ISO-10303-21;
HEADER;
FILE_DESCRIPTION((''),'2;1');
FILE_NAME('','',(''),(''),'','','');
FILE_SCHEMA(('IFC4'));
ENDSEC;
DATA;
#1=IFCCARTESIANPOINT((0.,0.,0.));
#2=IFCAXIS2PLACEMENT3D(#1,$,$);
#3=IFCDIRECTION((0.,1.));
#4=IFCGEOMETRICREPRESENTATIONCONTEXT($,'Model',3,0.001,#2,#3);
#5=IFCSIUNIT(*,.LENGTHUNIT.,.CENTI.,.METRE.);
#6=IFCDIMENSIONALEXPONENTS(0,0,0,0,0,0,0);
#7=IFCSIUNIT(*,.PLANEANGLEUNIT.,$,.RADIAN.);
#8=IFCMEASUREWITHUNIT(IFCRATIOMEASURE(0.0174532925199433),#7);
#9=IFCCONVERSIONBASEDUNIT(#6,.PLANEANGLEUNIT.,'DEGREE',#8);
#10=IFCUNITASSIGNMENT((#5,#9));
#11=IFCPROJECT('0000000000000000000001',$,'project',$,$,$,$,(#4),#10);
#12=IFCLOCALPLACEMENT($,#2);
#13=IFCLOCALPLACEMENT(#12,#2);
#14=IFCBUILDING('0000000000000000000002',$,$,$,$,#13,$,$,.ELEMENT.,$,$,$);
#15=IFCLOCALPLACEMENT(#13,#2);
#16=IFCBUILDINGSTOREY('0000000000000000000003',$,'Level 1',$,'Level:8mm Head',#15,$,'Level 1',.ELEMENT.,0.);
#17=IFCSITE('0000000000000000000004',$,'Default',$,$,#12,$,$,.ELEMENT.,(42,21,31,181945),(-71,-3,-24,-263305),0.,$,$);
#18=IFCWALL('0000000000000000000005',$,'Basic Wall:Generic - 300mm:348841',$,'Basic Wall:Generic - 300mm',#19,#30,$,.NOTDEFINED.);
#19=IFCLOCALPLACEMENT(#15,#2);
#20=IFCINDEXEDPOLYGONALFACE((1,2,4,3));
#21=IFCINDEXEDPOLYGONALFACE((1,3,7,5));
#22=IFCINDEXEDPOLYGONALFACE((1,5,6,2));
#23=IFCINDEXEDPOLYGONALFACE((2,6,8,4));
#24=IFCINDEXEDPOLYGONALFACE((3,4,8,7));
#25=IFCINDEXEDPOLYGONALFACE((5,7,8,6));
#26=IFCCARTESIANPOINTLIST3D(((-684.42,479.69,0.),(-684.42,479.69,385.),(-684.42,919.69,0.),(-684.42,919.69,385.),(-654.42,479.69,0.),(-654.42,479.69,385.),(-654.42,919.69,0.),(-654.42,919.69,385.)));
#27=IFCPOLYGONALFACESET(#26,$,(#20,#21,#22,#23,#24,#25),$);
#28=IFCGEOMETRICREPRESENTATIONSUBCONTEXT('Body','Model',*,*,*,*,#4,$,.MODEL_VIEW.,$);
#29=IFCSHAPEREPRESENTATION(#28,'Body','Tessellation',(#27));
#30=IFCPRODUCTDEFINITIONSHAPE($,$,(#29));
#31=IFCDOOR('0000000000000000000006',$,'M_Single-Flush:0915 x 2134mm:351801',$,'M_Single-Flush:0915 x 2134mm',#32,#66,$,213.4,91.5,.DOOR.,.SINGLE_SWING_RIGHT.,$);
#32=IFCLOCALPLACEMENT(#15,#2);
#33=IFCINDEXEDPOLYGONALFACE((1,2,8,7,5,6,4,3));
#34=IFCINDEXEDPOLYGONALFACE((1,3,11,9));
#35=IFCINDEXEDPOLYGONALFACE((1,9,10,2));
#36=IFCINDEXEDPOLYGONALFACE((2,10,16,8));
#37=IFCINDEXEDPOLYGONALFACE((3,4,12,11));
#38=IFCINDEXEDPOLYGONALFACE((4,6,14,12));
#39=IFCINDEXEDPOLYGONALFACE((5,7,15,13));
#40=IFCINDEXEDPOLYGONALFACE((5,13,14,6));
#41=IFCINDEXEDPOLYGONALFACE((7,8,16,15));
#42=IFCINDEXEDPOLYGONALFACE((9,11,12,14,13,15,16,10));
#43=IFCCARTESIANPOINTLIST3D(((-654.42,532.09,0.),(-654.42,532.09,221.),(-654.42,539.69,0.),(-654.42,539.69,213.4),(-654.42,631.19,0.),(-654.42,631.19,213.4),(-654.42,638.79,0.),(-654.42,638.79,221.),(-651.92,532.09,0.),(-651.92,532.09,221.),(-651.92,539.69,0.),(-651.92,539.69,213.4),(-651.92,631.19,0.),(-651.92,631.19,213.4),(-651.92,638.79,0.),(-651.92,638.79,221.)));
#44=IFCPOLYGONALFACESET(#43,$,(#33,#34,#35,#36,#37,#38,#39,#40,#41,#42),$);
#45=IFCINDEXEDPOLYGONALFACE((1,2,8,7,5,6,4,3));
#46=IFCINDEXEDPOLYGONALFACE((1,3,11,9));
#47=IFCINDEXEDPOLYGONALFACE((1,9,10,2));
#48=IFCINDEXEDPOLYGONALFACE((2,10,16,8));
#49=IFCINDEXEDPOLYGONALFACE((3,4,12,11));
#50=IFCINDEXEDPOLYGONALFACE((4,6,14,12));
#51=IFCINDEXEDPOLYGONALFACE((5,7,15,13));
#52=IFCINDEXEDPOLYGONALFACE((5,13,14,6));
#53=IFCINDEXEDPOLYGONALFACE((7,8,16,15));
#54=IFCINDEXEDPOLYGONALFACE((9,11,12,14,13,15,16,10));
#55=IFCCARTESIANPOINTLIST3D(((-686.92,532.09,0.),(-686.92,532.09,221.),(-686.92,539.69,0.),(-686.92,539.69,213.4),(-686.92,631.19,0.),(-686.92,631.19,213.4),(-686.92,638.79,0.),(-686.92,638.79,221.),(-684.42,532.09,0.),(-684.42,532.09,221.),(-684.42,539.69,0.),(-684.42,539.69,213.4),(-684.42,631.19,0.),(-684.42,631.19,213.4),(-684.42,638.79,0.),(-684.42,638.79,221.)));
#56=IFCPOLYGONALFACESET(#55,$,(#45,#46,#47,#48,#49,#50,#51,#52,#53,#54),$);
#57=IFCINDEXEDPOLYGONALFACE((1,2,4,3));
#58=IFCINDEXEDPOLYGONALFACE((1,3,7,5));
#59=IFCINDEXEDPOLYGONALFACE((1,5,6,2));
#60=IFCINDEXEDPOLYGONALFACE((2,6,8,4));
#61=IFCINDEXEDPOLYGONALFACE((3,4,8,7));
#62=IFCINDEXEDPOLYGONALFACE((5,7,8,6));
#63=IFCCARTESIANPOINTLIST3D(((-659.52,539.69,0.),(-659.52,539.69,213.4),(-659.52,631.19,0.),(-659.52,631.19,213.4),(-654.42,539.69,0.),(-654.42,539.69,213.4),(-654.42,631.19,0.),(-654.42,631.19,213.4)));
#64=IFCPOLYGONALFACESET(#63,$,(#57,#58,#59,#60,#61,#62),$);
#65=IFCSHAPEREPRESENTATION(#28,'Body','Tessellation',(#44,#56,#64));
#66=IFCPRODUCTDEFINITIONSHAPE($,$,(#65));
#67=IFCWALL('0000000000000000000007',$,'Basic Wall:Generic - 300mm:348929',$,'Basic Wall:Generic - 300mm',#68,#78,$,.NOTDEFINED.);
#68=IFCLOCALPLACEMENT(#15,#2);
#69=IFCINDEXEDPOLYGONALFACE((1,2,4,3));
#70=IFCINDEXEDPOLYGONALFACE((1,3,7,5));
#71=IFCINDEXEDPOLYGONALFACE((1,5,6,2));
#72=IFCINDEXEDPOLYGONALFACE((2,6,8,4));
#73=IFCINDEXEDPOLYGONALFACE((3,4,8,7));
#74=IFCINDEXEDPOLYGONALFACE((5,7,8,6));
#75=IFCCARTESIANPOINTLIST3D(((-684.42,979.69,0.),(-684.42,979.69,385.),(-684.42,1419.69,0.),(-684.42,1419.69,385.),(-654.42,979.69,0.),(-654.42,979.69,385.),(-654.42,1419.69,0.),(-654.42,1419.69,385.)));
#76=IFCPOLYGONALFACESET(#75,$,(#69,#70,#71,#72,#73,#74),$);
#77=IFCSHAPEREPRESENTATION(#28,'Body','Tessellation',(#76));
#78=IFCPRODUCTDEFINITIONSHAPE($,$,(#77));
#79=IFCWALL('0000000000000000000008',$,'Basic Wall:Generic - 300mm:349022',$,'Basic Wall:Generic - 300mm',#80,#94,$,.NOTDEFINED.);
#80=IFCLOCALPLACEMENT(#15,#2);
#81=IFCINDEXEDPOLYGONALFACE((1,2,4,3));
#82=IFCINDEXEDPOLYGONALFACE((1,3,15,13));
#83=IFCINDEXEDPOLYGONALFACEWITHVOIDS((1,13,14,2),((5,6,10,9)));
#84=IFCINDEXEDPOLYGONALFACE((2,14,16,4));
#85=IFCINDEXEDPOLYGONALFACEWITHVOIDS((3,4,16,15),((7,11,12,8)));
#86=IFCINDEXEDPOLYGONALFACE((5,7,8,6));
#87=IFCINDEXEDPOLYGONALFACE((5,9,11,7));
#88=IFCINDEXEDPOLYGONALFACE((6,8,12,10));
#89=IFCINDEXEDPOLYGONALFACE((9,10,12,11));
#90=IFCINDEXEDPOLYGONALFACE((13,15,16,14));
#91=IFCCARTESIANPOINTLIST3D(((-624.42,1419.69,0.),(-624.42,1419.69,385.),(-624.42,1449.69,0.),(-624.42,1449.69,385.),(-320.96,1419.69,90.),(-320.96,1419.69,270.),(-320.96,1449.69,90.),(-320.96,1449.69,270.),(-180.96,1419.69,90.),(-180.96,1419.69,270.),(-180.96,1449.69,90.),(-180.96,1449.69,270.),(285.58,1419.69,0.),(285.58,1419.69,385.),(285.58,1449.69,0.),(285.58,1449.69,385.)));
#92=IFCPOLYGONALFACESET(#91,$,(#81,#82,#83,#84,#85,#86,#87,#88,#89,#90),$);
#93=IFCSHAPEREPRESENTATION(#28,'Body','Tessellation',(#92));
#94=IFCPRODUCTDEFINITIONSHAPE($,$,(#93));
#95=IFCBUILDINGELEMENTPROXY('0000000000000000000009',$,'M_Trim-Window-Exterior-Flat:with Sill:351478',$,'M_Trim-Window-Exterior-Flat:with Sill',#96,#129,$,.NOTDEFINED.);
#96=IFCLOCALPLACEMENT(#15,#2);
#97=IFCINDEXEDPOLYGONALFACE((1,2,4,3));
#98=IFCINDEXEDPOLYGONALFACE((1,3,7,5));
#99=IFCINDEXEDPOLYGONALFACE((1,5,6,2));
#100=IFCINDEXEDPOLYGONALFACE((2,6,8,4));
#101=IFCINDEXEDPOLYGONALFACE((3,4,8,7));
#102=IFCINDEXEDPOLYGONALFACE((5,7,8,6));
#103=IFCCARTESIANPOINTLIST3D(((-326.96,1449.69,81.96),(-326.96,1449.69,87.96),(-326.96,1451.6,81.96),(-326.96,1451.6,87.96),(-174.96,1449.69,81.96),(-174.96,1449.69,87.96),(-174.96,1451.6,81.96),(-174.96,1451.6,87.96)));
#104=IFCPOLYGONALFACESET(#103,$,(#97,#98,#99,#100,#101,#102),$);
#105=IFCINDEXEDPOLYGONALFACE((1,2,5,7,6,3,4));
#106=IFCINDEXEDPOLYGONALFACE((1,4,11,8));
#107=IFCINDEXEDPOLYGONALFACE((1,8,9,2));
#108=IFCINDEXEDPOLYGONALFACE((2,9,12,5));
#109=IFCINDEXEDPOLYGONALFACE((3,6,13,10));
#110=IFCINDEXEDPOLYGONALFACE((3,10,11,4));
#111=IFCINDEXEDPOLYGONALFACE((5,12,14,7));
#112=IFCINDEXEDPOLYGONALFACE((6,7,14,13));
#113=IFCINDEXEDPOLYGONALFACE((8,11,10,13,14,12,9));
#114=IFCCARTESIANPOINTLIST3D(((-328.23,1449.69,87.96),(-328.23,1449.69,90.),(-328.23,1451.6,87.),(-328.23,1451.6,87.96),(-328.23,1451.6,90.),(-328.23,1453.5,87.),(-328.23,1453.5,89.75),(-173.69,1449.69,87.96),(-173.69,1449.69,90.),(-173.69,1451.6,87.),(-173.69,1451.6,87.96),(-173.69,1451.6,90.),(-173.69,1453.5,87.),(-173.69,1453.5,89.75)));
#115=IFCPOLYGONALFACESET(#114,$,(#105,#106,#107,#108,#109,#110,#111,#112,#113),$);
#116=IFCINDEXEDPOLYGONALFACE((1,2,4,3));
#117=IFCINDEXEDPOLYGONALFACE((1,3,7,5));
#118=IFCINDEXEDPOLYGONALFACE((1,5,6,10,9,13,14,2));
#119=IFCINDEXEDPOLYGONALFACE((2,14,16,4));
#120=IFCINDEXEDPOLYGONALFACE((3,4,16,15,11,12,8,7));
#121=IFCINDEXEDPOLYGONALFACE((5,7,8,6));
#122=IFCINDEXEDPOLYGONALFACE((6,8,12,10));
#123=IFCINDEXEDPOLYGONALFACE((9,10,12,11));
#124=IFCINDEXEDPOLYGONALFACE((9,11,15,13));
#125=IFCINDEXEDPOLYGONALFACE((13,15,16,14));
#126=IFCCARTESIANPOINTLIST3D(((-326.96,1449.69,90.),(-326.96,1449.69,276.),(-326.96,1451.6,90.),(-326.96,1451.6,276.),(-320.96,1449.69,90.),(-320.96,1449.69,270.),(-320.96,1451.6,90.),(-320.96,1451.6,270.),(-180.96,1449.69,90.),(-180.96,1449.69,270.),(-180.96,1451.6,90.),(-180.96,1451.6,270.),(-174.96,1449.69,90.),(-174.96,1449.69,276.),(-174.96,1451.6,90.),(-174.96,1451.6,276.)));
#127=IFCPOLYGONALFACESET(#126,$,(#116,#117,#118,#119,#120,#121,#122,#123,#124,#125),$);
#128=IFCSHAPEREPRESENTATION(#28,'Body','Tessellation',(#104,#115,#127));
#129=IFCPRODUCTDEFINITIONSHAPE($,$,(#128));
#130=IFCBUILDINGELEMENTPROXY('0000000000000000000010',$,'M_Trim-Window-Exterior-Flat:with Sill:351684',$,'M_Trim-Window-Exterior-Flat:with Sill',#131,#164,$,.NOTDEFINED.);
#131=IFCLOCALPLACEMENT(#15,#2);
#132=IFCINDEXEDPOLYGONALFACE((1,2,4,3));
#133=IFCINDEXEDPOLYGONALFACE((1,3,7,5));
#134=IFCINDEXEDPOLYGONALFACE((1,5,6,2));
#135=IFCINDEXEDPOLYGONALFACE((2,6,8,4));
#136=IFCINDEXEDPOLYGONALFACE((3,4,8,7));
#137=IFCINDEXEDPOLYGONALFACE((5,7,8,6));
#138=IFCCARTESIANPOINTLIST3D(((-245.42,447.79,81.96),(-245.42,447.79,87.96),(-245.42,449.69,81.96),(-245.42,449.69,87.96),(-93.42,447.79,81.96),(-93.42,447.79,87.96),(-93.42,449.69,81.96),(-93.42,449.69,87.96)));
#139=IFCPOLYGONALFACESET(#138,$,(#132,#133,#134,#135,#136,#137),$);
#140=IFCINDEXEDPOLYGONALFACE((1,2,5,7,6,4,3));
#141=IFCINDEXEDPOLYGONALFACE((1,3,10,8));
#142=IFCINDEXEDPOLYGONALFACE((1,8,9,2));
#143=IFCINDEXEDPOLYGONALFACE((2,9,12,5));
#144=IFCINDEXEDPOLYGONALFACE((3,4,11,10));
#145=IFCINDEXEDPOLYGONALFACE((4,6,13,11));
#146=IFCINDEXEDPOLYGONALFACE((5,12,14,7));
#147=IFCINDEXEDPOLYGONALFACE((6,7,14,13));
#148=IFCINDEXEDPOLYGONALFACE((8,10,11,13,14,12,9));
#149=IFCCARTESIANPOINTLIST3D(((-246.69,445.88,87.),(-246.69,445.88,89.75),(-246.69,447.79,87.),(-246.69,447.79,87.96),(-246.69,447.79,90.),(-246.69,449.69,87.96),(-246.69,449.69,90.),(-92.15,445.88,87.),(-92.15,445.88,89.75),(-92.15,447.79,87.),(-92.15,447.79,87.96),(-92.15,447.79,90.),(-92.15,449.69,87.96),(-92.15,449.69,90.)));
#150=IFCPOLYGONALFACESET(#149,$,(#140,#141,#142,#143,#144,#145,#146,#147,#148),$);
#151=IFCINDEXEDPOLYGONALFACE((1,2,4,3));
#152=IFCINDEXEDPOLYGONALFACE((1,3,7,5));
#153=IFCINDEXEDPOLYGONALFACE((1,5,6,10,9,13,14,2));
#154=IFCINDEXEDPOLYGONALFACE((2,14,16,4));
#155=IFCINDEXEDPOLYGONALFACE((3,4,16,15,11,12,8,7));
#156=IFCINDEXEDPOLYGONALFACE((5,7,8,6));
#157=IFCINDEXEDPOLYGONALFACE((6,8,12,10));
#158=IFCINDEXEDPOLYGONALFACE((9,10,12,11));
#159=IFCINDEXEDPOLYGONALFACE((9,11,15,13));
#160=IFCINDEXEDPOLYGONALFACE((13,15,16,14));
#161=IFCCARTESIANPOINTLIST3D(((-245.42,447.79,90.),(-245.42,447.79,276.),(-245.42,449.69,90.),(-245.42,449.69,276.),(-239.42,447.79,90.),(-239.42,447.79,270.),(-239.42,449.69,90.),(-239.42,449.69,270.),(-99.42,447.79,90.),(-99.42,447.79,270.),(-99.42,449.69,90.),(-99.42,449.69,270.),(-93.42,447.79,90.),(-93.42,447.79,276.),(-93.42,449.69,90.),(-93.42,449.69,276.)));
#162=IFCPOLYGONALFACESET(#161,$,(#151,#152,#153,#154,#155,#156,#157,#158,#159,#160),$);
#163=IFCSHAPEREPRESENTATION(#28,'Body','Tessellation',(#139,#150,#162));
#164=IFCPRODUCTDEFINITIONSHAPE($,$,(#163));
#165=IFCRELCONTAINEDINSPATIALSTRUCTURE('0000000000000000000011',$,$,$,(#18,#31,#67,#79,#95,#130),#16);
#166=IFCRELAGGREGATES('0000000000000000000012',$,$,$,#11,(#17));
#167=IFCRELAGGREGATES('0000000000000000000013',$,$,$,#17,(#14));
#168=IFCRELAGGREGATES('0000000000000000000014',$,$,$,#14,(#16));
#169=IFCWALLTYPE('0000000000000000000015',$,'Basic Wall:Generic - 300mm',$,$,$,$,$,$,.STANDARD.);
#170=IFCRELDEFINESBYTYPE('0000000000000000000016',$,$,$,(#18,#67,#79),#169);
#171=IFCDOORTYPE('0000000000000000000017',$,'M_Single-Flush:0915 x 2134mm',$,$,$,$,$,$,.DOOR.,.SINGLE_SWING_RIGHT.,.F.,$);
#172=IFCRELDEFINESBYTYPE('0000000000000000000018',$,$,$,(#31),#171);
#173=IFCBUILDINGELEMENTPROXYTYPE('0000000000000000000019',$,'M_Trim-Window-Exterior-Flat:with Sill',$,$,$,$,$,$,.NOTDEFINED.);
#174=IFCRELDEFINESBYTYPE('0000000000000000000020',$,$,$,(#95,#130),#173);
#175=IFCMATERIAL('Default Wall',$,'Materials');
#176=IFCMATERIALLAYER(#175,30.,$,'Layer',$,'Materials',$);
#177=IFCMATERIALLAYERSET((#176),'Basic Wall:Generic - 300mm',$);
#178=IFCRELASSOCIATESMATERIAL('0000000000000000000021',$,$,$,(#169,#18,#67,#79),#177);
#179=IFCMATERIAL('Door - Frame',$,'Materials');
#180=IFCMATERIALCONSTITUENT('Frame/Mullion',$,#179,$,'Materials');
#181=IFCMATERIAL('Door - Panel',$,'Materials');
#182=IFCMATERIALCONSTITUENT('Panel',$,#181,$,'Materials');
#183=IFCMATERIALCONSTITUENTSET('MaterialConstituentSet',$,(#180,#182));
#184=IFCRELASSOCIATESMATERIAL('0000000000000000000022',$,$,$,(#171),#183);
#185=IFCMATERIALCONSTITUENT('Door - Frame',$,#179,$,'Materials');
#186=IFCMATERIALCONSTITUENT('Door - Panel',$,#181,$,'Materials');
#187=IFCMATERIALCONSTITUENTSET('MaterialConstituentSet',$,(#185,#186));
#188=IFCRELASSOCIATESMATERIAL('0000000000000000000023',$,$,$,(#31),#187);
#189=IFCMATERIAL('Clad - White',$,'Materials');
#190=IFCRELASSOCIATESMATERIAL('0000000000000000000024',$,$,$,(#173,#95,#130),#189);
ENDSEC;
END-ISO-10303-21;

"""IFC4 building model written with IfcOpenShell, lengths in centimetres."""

from ifc_helpers import new_model, entity, si_unit, converted_unit, direction, frame, frame_2d, origin, place, context, subcontext, project, spatial, polyline, rectangle, outline, extrude, clip, bounded_halfspace, source, transform, mapped, material, layer, layer_set, layer_usage, constituent, constituent_set, type_object, type_shapes, element, fill, save


model = new_model("IFC4")

# Units and contexts
model_context = context("Model", 3, precision=0.001, world=origin(), true_north=direction((0.0, 1.0)))
body_context = subcontext(model_context, "Body", "Model", "MODEL_VIEW")
ifc_project = project(units=[si_unit("LENGTHUNIT", "METRE", prefix="CENTI"), converted_unit("PLANEANGLEUNIT", "DEGREE", entity("IfcRatioMeasure", 0.0174532925199433), si_unit("PLANEANGLEUNIT", "RADIAN"), dimensions=[0, 0, 0, 0, 0, 0, 0])], contexts=[model_context])

# Site, building, storey
site_placement = place(None, origin())
site = spatial("IfcSite", under=ifc_project, at=site_placement, Name="Default", CompositionType="ELEMENT", RefLatitude=(42, 21, 31, 181945), RefLongitude=(-71, -3, -24, -263305), RefElevation=0.0)
building_placement = place(site_placement, origin())
building = spatial("IfcBuilding", under=site, at=building_placement, CompositionType="ELEMENT")
storey_placement = place(building_placement, origin())
storey = spatial("IfcBuildingStorey", under=building, at=storey_placement, Name="Level 1", ObjectType="Level:8mm Head", LongName="Level 1", CompositionType="ELEMENT", Elevation=0.0)

# Shared definitions
ifc_material_1 = material(Name="Default Wall", Category="Materials")

# Wall, opening, door
ifc_layer_1 = layer(ifc_material_1, 30.0, Name="Layer", Category="Materials")
ifc_layer_set_1 = layer_set([ifc_layer_1], Name="Basic Wall:Generic - 300mm")
ifc_layer_usage_1 = layer_usage(ifc_layer_set_1, "AXIS2", "NEGATIVE", 15.0)
wall_type = type_object("IfcWallType", Name="Basic Wall:Generic - 300mm", PredefinedType="STANDARD", material=ifc_layer_set_1)
wall_1_placement = place(storey_placement, frame((-669.42, 479.69, 0.0), z_axis=(0.0, 0.0, 1.0), x_axis=(0.0, 1.0, 0.0)))
wall_1 = element("IfcWall", 1, at=wall_1_placement, inside=storey, type_object=wall_type, material=ifc_layer_usage_1, Name="Basic Wall:Generic - 300mm:348841", ObjectType="Basic Wall:Generic - 300mm", PredefinedType="NOTDEFINED", context=body_context, shape_type="Clipping", body=[
    clip(extrude(rectangle(XDim=440.0, YDim=30.0, at=frame_2d((220.0, 0.0), x_axis=(-1.0, 0.0))), origin(), (0.0, 0.0, 1.0), 385.0), bounded_halfspace(frame((0.0, -15.0, 385.0), z_axis=(0.0, 0.0, -1.0), x_axis=(0.0, -1.0, 0.0)), True, frame((0.0, -15.0, 385.0)), polyline([(0.0, 0.0), (440.0, 0.0), (440.0, 30.0), (0.0, 30.0), (0.0, 0.0)]))),
])
opening_1_placement = place(wall_1_placement, frame((151.5, 45.0, 0.0)))
opening_1 = element("IfcOpeningElement", 2, at=opening_1_placement, cuts=wall_1, PredefinedType="OPENING", context=body_context, shape_type="SweptSolid", body=[
    extrude(rectangle(XDim=91.5, YDim=213.4, at=frame_2d((106.7, 45.75), x_axis=(0.0, 1.0))), frame((0.0, 0.0, 0.0), z_axis=(0.0, -1.0, 0.0), x_axis=(0.0, 0.0, 1.0)), (0.0, 0.0, 1.0), 30.0),
])
ifc_material_2 = material(Name="Door - Frame", Category="Materials")
ifc_constituent_1 = constituent(ifc_material_2, Name="Door - Frame", Category="Materials")
ifc_material_3 = material(Name="Door - Panel", Category="Materials")
ifc_constituent_2 = constituent(ifc_material_3, Name="Door - Panel", Category="Materials")
ifc_constituent_set_1 = constituent_set(constituents=[ifc_constituent_1, ifc_constituent_2], Name="MaterialConstituentSet")
ifc_constituent_3 = constituent(ifc_material_2, Name="Frame/Mullion", Category="Materials")
ifc_constituent_4 = constituent(ifc_material_3, Name="Panel", Category="Materials")
ifc_constituent_set_2 = constituent_set(constituents=[ifc_constituent_3, ifc_constituent_4], Name="MaterialConstituentSet")
door_type = type_object("IfcDoorType", Name="M_Single-Flush:0915 x 2134mm", OperationType="SINGLE_SWING_RIGHT", ParameterTakesPrecedence=False, PredefinedType="DOOR", material=ifc_constituent_set_2)
shared_shape_1 = source(origin(), body_context, "Body", "SweptSolid", [
    extrude(outline(polyline([(-53.35, -112.4), (53.35, -112.4), (53.35, 108.6), (45.75, 108.6), (45.75, -104.8), (-45.75, -104.8), (-45.75, 108.6), (-53.35, 108.6), (-53.35, -112.4)])), frame((45.75, 30.0, 108.6), z_axis=(0.0, 1.0, 0.0), x_axis=(1.0, 0.0, 0.0)), (0.0, 0.0, 1.0), 2.5),
    extrude(outline(polyline([(-112.4, -53.35), (108.6, -53.35), (108.6, -45.75), (-104.8, -45.75), (-104.8, 45.75), (108.6, 45.75), (108.6, 53.35), (-112.4, 53.35), (-112.4, -53.35)])), frame((45.75, -2.5, 108.6), z_axis=(0.0, 1.0, 0.0), x_axis=(0.0, 0.0, -1.0)), (0.0, 0.0, 1.0), 2.5),
    extrude(rectangle(XDim=5.1, YDim=91.5, at=frame_2d((0.0, 0.0), x_axis=(1.0, 0.0))), frame((45.75, 27.45, 0.0), z_axis=(0.0, 0.0, 1.0), x_axis=(0.0, 1.0, 0.0)), (0.0, 0.0, 1.0), 213.4),
])
type_shapes(door_type, [shared_shape_1])
door_placement = place(opening_1_placement, frame((0.0, -30.0, 0.0), z_axis=(0.0, 0.0, 1.0), x_axis=(-1.0, 0.0, 0.0)))
door = element("IfcDoor", 3, at=door_placement, inside=storey, type_object=door_type, material=ifc_constituent_set_1, Name="M_Single-Flush:0915 x 2134mm:351801", ObjectType="M_Single-Flush:0915 x 2134mm", OperationType="SINGLE_SWING_RIGHT", OverallHeight=213.4, OverallWidth=91.5, PredefinedType="DOOR", context=body_context, shape_type="MappedRepresentation", body=[
    mapped(shared_shape_1, transform((0.0, 0.0, 0.0), scale=1.0)),
])
fill(opening_1, door)

# Wall
ifc_layer_usage_2 = layer_usage(ifc_layer_set_1, "AXIS2", "NEGATIVE", 15.0)
wall_2_placement = place(storey_placement, frame((-669.42, 979.69, 0.0), z_axis=(0.0, 0.0, 1.0), x_axis=(0.0, 1.0, 0.0)))
element("IfcWall", 4, at=wall_2_placement, inside=storey, type_object=wall_type, material=ifc_layer_usage_2, Name="Basic Wall:Generic - 300mm:348929", ObjectType="Basic Wall:Generic - 300mm", PredefinedType="NOTDEFINED", context=body_context, shape_type="Clipping", body=[
    clip(extrude(rectangle(XDim=440.0, YDim=30.0, at=frame_2d((220.0, 0.0), x_axis=(-1.0, 0.0))), origin(), (0.0, 0.0, 1.0), 385.0), bounded_halfspace(frame((0.0, -15.0, 385.0), z_axis=(0.0, 0.0, -1.0), x_axis=(0.0, -1.0, 0.0)), True, frame((0.0, -15.0, 385.0)), polyline([(0.0, 0.0), (440.0, 0.0), (440.0, 30.0), (0.0, 30.0), (0.0, 0.0)]))),
])

# Wall, opening
ifc_layer_usage_3 = layer_usage(ifc_layer_set_1, "AXIS2", "NEGATIVE", 15.0)
wall_3_placement = place(storey_placement, frame((-624.42, 1434.69, 0.0)))
wall_3 = element("IfcWall", 5, at=wall_3_placement, inside=storey, type_object=wall_type, material=ifc_layer_usage_3, Name="Basic Wall:Generic - 300mm:349022", ObjectType="Basic Wall:Generic - 300mm", PredefinedType="NOTDEFINED", context=body_context, shape_type="Clipping", body=[
    clip(extrude(rectangle(XDim=910.0, YDim=30.0, at=frame_2d((455.0, 0.0), x_axis=(-1.0, 0.0))), origin(), (0.0, 0.0, 1.0), 385.0), bounded_halfspace(frame((0.0, -15.0, 385.0), z_axis=(0.0, 0.0, -1.0), x_axis=(1.0, 0.0, 0.0)), True, frame((0.0, -15.0, 385.0)), polyline([(0.0, 0.0), (910.0, 0.0), (910.0, 30.0), (0.0, 30.0), (0.0, 0.0)]))),
])
opening_2_placement = place(wall_3_placement, frame((443.46, 15.0, 90.0)))
element("IfcOpeningElement", 6, at=opening_2_placement, cuts=wall_3, PredefinedType="OPENING", context=body_context, shape_type="SweptSolid", body=[
    extrude(rectangle(XDim=180.0, YDim=140.0, at=frame_2d((90.0, 70.0), x_axis=(-1.0, 0.0))), frame((0.0, 0.0, 0.0), z_axis=(0.0, -1.0, 0.0), x_axis=(0.0, 0.0, 1.0)), (0.0, 0.0, 1.0), 30.0),
])

# Building element proxies
ifc_material_4 = material(Name="Clad - White", Category="Materials")
building_element_proxy_type_1 = type_object("IfcBuildingElementProxyType", Name="M_Trim-Window-Exterior-Flat:with Sill", PredefinedType="NOTDEFINED", material=ifc_material_4)
shared_shape_2 = source(origin(), body_context, "Body", "SweptSolid", [
    extrude(rectangle(XDim=152.0, YDim=6.0, at=frame_2d((0.0, 0.0), x_axis=(1.0, 0.0))), frame((0.0, -185.04, 0.0), z_axis=(0.0, 0.0, 1.0), x_axis=(-1.0, 0.0, 0.0)), (0.0, 0.0, 1.0), 1.91),
    extrude(outline(polyline([(-1.9, -1.52), (0.0, -1.52), (0.0, -0.57), (1.9, -0.57), (1.9, 1.48), (0.0, 1.48), (-1.9, 1.23), (-1.9, -1.52)])), frame((-77.27, -181.48, 1.9), z_axis=(1.0, 0.0, 0.0), x_axis=(0.0, 0.0, -1.0)), (0.0, 0.0, 1.0), 154.54),
    extrude(outline(polyline([(-94.5, -76.0), (91.5, -76.0), (91.5, -70.0), (-88.5, -70.0), (-88.5, 70.0), (91.5, 70.0), (91.5, 76.0), (-94.5, 76.0), (-94.5, -76.0)])), frame((0.0, -88.5, 0.0), z_axis=(0.0, 0.0, 1.0), x_axis=(0.0, -1.0, 0.0)), (0.0, 0.0, 1.0), 1.91),
])
type_shapes(building_element_proxy_type_1, [shared_shape_2])
for number, where, z_axis, x_axis, name in (
    (7, (-250.96, 1449.69, 270.0), (0.0, 1.0, 0.0), (-1.0, 0.0, 0.0), "M_Trim-Window-Exterior-Flat:with Sill:351478"),
    (8, (-169.42, 449.69, 270.0), (0.0, -1.0, 0.0), (1.0, 0.0, 0.0), "M_Trim-Window-Exterior-Flat:with Sill:351684"),
):
    element("IfcBuildingElementProxy", number, at=place(storey_placement, frame(where, z_axis=z_axis, x_axis=x_axis)), inside=storey, type_object=building_element_proxy_type_1, material=ifc_material_4, Name=name, ObjectType="M_Trim-Window-Exterior-Flat:with Sill", PredefinedType="NOTDEFINED", context=body_context, shape_type="MappedRepresentation", body=[
        mapped(shared_shape_2, transform((0.0, 0.0, 0.0), scale=1.0)),
    ])

save(model, "model.ifc")
